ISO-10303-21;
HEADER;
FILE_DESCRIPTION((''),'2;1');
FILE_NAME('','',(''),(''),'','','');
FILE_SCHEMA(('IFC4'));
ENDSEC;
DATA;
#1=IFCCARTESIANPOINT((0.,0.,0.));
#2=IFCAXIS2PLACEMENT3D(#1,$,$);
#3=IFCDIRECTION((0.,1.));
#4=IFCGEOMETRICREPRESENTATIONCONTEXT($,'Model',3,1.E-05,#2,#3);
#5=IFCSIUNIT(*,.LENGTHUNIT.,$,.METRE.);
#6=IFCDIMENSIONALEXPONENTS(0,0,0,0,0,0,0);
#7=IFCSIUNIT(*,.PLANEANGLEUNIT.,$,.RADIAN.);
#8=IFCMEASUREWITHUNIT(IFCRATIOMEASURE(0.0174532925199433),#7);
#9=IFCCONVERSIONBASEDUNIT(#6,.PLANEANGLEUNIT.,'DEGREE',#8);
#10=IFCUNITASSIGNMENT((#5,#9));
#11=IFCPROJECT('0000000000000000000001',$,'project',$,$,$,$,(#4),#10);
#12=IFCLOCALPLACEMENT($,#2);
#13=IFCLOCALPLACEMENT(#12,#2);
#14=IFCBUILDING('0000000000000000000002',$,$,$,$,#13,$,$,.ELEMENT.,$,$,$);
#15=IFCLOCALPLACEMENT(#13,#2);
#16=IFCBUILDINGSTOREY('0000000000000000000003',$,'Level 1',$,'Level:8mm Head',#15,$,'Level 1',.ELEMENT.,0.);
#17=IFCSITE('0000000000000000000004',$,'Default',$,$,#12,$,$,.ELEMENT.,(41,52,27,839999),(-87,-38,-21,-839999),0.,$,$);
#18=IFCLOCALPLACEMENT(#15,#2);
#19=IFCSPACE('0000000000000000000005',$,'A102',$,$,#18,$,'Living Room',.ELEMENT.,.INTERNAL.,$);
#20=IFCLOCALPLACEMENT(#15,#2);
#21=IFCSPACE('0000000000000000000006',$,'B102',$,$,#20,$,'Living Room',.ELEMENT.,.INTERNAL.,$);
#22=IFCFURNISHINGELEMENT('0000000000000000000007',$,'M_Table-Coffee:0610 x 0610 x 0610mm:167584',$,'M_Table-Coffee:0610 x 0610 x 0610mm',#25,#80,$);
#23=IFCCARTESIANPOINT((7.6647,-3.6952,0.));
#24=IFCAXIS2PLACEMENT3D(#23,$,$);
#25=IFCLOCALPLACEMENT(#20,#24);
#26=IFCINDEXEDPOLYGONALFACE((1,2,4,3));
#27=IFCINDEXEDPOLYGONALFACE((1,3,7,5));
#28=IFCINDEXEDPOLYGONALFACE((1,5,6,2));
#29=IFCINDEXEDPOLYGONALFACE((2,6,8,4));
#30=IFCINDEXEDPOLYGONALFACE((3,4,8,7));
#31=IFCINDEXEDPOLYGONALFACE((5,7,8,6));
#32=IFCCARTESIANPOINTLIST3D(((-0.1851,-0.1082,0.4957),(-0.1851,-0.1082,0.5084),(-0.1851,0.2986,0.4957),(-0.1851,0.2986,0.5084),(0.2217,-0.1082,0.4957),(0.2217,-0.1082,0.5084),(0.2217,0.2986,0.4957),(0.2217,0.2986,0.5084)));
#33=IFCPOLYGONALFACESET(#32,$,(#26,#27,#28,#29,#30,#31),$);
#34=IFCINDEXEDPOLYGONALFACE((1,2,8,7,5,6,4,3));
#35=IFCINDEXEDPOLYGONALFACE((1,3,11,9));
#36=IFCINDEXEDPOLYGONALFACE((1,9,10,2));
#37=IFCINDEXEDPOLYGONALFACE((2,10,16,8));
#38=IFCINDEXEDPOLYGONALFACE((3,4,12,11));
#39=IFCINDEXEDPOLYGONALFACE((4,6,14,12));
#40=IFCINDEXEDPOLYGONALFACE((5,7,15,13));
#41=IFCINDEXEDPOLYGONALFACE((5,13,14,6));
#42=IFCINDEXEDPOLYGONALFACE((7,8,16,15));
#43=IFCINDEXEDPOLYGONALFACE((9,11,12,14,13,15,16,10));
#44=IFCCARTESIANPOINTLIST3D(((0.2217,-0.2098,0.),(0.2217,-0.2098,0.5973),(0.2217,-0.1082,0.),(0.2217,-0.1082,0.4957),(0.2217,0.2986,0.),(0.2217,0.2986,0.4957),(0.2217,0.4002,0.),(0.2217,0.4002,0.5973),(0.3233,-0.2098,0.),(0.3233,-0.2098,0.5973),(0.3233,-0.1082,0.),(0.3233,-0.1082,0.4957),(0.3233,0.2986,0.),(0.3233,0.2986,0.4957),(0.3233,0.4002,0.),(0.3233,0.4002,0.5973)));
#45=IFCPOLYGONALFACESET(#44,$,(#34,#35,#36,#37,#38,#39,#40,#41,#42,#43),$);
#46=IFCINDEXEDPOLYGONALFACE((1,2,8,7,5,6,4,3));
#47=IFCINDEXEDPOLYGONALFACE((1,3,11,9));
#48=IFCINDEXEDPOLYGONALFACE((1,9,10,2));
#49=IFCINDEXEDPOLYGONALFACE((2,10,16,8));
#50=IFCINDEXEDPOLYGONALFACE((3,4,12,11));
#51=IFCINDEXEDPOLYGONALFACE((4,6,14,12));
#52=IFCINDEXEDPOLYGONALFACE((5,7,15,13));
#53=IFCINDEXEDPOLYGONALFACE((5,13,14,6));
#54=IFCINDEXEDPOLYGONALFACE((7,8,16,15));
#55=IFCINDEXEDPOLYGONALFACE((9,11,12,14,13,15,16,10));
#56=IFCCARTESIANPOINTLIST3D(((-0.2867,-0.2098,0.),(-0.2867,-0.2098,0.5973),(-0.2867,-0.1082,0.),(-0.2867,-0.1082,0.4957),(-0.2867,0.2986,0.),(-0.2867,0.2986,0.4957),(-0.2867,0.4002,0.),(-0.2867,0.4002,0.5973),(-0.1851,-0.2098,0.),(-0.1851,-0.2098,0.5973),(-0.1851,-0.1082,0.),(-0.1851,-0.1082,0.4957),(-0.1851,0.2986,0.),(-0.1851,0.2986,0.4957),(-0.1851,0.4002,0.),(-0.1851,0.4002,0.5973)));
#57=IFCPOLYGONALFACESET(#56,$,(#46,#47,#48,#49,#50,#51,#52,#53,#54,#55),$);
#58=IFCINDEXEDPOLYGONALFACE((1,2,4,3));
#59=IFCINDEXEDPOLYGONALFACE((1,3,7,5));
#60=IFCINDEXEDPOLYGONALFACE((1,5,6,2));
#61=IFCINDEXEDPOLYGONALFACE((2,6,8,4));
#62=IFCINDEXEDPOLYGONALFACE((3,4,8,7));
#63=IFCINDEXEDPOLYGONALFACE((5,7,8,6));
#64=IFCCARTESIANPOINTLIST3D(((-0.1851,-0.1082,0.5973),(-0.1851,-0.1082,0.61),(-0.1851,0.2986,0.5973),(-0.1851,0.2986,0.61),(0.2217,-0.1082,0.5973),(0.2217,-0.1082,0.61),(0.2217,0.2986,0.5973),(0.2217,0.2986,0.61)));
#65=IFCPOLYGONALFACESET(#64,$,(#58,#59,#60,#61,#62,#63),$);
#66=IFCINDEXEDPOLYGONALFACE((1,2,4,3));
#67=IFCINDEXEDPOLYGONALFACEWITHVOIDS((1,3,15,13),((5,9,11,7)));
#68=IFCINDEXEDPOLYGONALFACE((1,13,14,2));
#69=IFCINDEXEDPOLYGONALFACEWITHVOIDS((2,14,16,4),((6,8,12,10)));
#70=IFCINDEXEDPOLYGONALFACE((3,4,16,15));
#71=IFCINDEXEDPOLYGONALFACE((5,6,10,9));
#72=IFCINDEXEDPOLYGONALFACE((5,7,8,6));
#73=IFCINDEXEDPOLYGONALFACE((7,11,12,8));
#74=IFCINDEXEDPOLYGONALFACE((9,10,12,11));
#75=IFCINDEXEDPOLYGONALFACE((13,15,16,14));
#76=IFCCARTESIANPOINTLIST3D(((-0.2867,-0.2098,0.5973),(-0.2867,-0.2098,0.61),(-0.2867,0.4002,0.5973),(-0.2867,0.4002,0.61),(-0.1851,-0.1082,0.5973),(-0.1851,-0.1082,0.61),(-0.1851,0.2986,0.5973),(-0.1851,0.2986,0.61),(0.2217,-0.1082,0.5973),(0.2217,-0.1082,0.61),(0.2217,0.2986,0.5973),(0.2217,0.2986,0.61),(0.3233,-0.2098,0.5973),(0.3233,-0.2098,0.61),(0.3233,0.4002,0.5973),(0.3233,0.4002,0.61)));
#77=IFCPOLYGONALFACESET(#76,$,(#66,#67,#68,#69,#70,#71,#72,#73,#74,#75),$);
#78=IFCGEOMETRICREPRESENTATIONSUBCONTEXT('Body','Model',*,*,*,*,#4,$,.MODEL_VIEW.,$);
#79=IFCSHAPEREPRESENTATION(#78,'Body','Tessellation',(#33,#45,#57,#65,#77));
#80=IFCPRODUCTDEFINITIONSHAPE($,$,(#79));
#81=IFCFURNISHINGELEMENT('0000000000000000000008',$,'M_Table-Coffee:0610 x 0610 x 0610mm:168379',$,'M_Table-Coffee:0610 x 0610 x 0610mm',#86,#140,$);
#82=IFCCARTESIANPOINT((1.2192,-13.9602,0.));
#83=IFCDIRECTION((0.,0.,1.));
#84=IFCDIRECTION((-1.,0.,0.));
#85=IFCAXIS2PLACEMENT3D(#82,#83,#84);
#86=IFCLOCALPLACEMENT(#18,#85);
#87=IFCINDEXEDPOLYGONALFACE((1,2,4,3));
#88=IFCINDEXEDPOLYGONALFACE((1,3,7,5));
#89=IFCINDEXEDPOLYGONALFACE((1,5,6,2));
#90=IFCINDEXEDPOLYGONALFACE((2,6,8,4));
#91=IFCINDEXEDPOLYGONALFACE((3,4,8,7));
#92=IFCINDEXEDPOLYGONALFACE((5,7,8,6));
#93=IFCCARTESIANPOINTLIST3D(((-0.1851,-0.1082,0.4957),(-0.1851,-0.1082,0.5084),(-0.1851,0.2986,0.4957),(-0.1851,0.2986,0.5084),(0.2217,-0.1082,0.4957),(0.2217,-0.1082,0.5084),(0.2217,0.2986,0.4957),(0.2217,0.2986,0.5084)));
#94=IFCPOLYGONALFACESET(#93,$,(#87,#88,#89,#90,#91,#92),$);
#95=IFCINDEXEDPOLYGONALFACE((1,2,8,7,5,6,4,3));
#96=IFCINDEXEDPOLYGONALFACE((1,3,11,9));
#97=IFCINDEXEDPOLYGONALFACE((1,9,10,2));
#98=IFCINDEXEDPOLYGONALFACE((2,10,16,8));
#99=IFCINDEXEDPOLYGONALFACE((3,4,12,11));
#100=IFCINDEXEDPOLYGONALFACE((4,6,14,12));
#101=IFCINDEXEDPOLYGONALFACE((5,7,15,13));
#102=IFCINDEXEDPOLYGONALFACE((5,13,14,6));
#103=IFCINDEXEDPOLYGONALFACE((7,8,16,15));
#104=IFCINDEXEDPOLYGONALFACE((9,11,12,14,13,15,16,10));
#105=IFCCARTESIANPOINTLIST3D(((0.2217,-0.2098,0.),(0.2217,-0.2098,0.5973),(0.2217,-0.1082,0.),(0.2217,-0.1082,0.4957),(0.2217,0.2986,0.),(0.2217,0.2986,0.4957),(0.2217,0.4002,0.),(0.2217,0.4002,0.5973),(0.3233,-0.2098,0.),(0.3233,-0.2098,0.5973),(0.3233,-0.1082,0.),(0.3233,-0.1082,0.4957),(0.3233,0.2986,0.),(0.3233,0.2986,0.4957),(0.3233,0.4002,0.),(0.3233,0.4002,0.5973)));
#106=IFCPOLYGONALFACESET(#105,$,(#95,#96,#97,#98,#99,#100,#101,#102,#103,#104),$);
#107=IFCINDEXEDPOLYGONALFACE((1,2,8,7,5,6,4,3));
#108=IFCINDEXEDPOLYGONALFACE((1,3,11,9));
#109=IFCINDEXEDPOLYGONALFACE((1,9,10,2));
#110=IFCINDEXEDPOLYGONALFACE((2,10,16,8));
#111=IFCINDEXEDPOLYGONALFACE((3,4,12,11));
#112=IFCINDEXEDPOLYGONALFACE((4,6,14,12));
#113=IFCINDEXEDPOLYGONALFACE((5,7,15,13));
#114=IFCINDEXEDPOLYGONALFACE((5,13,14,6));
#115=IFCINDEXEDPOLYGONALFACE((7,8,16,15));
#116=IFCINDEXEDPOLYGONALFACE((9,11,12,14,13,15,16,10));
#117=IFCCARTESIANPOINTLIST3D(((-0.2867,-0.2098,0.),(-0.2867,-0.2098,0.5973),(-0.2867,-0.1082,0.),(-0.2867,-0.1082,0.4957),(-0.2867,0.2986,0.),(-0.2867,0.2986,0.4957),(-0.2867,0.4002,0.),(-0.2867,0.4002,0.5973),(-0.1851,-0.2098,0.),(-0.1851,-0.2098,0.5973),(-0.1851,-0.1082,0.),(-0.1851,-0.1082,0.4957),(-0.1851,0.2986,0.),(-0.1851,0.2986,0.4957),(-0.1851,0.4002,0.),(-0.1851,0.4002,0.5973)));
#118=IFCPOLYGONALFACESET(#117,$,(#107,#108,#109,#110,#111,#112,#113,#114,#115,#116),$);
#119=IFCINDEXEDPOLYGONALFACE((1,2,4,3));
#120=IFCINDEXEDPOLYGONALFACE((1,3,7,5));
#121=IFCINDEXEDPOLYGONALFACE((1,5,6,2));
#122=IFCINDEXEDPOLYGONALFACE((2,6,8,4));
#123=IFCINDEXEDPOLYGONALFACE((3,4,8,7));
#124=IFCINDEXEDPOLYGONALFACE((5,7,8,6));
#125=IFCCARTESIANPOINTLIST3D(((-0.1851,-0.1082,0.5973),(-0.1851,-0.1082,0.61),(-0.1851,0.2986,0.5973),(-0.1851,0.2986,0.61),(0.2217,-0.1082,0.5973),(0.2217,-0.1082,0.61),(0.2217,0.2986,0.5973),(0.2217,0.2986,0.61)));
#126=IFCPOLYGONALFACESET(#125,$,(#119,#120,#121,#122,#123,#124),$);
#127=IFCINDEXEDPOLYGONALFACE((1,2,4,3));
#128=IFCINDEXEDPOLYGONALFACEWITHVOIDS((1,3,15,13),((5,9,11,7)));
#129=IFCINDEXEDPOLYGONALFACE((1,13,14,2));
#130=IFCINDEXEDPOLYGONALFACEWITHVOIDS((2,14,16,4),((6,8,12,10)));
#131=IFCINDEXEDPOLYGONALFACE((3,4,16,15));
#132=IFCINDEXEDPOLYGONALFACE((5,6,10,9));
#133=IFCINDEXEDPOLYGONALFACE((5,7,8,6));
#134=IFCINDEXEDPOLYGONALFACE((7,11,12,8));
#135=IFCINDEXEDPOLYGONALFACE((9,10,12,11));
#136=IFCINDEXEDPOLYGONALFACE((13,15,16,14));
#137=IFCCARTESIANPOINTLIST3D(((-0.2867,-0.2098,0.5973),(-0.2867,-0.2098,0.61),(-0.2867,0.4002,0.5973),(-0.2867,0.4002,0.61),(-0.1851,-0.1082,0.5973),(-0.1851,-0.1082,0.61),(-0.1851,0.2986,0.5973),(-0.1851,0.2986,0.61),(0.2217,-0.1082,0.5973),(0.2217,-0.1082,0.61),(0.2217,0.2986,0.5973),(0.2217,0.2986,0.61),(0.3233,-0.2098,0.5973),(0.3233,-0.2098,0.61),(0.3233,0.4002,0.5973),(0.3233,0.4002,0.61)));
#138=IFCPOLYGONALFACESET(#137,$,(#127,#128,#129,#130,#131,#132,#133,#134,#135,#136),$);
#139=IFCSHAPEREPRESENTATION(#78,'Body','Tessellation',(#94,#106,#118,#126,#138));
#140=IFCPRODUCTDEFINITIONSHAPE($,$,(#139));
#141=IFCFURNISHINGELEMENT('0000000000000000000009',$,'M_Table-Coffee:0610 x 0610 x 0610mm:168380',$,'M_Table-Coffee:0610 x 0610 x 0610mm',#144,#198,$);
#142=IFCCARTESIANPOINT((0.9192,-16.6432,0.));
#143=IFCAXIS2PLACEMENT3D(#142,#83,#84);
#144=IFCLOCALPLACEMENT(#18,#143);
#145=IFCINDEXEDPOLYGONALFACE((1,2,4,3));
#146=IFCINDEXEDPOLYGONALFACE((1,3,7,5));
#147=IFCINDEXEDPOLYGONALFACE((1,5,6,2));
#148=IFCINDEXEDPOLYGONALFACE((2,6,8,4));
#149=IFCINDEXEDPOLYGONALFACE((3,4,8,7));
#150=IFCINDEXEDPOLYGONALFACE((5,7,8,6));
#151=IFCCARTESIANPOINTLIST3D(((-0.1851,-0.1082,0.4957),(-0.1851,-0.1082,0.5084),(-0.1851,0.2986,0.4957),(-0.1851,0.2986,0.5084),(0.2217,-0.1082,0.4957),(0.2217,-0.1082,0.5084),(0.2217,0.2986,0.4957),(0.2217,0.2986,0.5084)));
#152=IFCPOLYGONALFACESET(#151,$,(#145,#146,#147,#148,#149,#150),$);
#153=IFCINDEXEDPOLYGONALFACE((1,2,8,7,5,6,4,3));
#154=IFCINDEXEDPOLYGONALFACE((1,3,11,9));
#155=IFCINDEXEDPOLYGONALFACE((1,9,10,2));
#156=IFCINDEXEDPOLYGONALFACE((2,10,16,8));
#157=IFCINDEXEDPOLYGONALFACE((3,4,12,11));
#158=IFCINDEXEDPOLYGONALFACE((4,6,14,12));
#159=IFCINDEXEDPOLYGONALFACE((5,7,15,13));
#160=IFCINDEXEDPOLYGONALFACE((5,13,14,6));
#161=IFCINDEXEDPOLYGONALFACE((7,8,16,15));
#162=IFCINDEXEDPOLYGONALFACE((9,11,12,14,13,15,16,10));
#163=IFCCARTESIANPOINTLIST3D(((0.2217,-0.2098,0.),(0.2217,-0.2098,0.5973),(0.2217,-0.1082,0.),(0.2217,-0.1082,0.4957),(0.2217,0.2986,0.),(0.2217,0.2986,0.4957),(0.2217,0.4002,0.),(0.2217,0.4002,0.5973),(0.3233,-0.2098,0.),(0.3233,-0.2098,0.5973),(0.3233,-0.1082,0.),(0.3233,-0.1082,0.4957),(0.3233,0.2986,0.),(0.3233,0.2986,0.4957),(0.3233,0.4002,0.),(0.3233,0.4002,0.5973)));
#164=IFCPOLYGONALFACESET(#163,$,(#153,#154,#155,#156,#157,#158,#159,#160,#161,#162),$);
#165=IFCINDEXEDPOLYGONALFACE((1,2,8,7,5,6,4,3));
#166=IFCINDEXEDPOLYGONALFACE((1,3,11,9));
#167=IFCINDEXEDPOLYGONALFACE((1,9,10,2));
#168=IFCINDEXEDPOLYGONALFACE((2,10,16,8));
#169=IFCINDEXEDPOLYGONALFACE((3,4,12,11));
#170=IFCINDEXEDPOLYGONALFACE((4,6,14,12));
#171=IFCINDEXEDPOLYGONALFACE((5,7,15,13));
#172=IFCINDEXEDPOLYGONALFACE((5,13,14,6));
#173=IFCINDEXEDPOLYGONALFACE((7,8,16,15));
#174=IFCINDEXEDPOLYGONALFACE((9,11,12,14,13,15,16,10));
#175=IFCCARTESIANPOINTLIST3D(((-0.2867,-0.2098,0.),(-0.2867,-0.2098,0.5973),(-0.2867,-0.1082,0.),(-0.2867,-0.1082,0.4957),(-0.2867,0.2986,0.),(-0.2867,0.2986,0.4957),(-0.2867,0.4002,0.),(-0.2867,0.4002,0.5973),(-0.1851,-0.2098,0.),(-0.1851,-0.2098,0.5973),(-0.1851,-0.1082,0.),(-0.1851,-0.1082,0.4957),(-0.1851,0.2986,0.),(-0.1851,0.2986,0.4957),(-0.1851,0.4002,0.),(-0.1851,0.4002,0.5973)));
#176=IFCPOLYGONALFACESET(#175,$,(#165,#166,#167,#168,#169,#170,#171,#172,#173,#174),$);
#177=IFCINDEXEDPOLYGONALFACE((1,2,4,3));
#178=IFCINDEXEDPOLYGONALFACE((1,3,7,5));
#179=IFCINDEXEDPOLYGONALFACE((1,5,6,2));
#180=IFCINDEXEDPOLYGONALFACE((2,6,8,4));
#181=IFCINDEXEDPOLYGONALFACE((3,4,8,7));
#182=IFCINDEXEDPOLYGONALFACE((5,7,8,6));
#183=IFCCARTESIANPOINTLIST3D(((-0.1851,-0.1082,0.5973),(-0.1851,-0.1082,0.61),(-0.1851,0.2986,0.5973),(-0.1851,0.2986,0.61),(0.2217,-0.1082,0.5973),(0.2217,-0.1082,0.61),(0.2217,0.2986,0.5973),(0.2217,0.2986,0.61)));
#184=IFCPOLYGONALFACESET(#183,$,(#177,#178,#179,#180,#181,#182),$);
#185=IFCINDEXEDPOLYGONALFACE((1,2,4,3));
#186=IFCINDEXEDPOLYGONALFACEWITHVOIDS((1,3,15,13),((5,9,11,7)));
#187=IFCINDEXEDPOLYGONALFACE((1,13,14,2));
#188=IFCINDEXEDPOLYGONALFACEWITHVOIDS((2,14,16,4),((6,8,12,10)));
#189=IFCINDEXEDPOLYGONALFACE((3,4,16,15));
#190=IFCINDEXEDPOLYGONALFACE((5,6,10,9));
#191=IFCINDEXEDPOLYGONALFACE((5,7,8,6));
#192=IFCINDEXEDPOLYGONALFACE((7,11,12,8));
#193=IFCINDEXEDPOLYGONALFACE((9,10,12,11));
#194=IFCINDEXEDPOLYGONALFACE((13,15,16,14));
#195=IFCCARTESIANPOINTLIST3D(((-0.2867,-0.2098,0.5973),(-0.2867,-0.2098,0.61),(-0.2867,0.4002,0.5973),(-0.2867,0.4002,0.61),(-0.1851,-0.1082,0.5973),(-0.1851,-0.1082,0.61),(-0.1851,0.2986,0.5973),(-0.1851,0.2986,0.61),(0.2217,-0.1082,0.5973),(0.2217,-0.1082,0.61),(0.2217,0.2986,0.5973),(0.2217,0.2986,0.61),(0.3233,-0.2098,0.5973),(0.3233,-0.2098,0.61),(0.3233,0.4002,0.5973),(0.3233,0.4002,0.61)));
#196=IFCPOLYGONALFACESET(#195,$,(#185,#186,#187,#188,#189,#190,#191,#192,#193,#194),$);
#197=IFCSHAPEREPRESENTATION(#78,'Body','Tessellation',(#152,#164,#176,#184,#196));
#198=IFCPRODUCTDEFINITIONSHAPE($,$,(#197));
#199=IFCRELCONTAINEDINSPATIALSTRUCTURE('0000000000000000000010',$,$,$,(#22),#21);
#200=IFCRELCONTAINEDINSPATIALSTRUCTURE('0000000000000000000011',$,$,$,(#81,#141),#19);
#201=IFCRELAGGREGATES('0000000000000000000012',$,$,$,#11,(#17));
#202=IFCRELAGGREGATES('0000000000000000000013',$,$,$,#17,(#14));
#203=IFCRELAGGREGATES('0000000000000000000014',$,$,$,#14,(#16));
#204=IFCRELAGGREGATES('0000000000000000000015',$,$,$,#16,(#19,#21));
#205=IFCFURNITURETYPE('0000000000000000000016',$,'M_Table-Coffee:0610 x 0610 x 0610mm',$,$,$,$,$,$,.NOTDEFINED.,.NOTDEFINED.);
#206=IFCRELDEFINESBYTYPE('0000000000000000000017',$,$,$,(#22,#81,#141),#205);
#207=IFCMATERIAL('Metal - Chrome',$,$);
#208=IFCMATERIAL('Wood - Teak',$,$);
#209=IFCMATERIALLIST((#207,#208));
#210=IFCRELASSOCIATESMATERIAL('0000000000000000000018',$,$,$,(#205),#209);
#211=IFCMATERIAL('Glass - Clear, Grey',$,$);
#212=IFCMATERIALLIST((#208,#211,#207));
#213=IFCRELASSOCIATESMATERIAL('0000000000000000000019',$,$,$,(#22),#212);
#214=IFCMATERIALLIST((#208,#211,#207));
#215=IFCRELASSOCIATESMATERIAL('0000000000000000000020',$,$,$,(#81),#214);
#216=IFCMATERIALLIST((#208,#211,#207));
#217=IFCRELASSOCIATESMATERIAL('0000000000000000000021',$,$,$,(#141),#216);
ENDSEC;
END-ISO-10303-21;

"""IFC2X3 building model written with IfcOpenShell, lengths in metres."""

from ifc_helpers import new_model, entity, si_unit, converted_unit, direction, frame, origin, origin_2d_with_axis, place, context, subcontext, project, spatial, polyline, rectangle, outline, extrude, source, transform, mapped, material, material_list, type_object, type_shapes, element, save


model = new_model("IFC2X3")

# Units and contexts
model_context = context("Model", 3, precision=1e-05, world=origin(), true_north=direction((0.0, 1.0)))
body_context = subcontext(model_context, "Body", "Model", "MODEL_VIEW")
ifc_project = project(units=[si_unit("LENGTHUNIT", "METRE"), converted_unit("PLANEANGLEUNIT", "DEGREE", entity("IfcRatioMeasure", 0.0174532925199433), si_unit("PLANEANGLEUNIT", "RADIAN"), dimensions=[0, 0, 0, 0, 0, 0, 0])], contexts=[model_context])

# Site, building, storey
site_placement = place(None, origin())
site = spatial("IfcSite", under=ifc_project, at=site_placement, Name="Default", CompositionType="ELEMENT", RefLatitude=(41, 52, 27, 839999), RefLongitude=(-87, -38, -21, -839999), RefElevation=0.0)
building_placement = place(site_placement, origin())
building = spatial("IfcBuilding", under=site, at=building_placement, CompositionType="ELEMENT")
storey_placement = place(building_placement, origin())
storey = spatial("IfcBuildingStorey", under=building, at=storey_placement, Name="Level 1", ObjectType="Level:8mm Head", LongName="Level 1", CompositionType="ELEMENT", Elevation=0.0)

# Shared definitions
space_1_placement = place(storey_placement, origin())
space_1 = spatial("IfcSpace", under=storey, at=space_1_placement, Name="A102", LongName="Living Room", CompositionType="ELEMENT", InteriorOrExteriorSpace="INTERNAL")

# Shared definitions
space_2_placement = place(storey_placement, origin())
space_2 = spatial("IfcSpace", under=storey, at=space_2_placement, Name="B102", LongName="Living Room", CompositionType="ELEMENT", InteriorOrExteriorSpace="INTERNAL")

# Furnishing elements
ifc_material_1 = material(Name="Wood - Teak")
ifc_material_2 = material(Name="Glass - Clear, Grey")
ifc_material_3 = material(Name="Metal - Chrome")
ifc_material_list_1 = material_list([ifc_material_1, ifc_material_2, ifc_material_3])
ifc_material_list_2 = material_list([ifc_material_3, ifc_material_1])
furniture_type_1 = type_object("IfcFurnitureType", Name="M_Table-Coffee:0610 x 0610 x 0610mm", material=ifc_material_list_2)
shared_shape_1 = source(origin(), body_context, "Body", "SweptSolid", [
    extrude(rectangle(XDim=0.4068, YDim=0.4068, at=origin_2d_with_axis()), frame((0.0183, 0.0952, 0.4957), z_axis=(0.0, 0.0, 1.0), x_axis=(-1.0, 0.0, 0.0)), (0.0, 0.0, 1.0), 0.0127),
    extrude(outline(polyline([(-0.2732, -0.305), (0.324, -0.305), (0.324, 0.305), (-0.2732, 0.305), (-0.2732, 0.2034), (0.2225, 0.2034), (0.2225, -0.2034), (-0.2732, -0.2034), (-0.2732, -0.305)])), frame((0.2217, 0.0952, 0.2732), z_axis=(1.0, 0.0, 0.0), x_axis=(0.0, 0.0, 1.0)), (0.0, 0.0, 1.0), 0.1016),
    extrude(outline(polyline([(-0.305, -0.3241), (0.305, -0.3241), (0.305, 0.2733), (0.2034, 0.2733), (0.2034, -0.2224), (-0.2034, -0.2224), (-0.2034, 0.2733), (-0.305, 0.2733), (-0.305, -0.3241)])), frame((-0.2867, 0.0952, 0.2733), z_axis=(1.0, 0.0, 0.0), x_axis=(0.0, -1.0, 0.0)), (0.0, 0.0, 1.0), 0.1016),
    extrude(rectangle(XDim=0.4068, YDim=0.4068, at=origin_2d_with_axis()), frame((0.0183, 0.0952, 0.5973), z_axis=(0.0, 0.0, 1.0), x_axis=(-1.0, 0.0, 0.0)), (0.0, 0.0, 1.0), 0.0127),
    extrude(outline(polyline([(-0.305, -0.305), (0.305, -0.305), (0.305, 0.305), (-0.305, 0.305), (-0.305, -0.305)]), holes=[polyline([(-0.2034, -0.2034), (-0.2034, 0.2034), (0.2034, 0.2034), (0.2034, -0.2034), (-0.2034, -0.2034)])]), frame((0.0183, 0.0952, 0.5973), z_axis=(0.0, 0.0, 1.0), x_axis=(-1.0, 0.0, 0.0)), (0.0, 0.0, 1.0), 0.0127),
])
type_shapes(furniture_type_1, [shared_shape_1])
furnishing_1_placement = place(space_2_placement, frame((7.6647, -3.6952, 0.0)))
element("IfcFurnishingElement", 1, at=furnishing_1_placement, inside=space_2, type_object=furniture_type_1, material=ifc_material_list_1, Name="M_Table-Coffee:0610 x 0610 x 0610mm:167584", ObjectType="M_Table-Coffee:0610 x 0610 x 0610mm", context=body_context, shape_type="MappedRepresentation", body=[
    mapped(shared_shape_1, transform((0.0, 0.0, 0.0), scale=1.0)),
])
ifc_material_list_3 = material_list([ifc_material_1, ifc_material_2, ifc_material_3])
furnishing_2_placement = place(space_1_placement, frame((1.2192, -13.9602, 0.0), z_axis=(0.0, 0.0, 1.0), x_axis=(-1.0, 0.0, 0.0)))
element("IfcFurnishingElement", 2, at=furnishing_2_placement, inside=space_1, type_object=furniture_type_1, material=ifc_material_list_3, Name="M_Table-Coffee:0610 x 0610 x 0610mm:168379", ObjectType="M_Table-Coffee:0610 x 0610 x 0610mm", context=body_context, shape_type="MappedRepresentation", body=[
    mapped(shared_shape_1, transform((0.0, 0.0, 0.0), scale=1.0)),
])
ifc_material_list_4 = material_list([ifc_material_1, ifc_material_2, ifc_material_3])
furnishing_3_placement = place(space_1_placement, frame((0.9192, -16.6432, 0.0), z_axis=(0.0, 0.0, 1.0), x_axis=(-1.0, 0.0, 0.0)))
element("IfcFurnishingElement", 3, at=furnishing_3_placement, inside=space_1, type_object=furniture_type_1, material=ifc_material_list_4, Name="M_Table-Coffee:0610 x 0610 x 0610mm:168380", ObjectType="M_Table-Coffee:0610 x 0610 x 0610mm", context=body_context, shape_type="MappedRepresentation", body=[
    mapped(shared_shape_1, transform((0.0, 0.0, 0.0), scale=1.0)),
])

save(model, "model.ifc")
